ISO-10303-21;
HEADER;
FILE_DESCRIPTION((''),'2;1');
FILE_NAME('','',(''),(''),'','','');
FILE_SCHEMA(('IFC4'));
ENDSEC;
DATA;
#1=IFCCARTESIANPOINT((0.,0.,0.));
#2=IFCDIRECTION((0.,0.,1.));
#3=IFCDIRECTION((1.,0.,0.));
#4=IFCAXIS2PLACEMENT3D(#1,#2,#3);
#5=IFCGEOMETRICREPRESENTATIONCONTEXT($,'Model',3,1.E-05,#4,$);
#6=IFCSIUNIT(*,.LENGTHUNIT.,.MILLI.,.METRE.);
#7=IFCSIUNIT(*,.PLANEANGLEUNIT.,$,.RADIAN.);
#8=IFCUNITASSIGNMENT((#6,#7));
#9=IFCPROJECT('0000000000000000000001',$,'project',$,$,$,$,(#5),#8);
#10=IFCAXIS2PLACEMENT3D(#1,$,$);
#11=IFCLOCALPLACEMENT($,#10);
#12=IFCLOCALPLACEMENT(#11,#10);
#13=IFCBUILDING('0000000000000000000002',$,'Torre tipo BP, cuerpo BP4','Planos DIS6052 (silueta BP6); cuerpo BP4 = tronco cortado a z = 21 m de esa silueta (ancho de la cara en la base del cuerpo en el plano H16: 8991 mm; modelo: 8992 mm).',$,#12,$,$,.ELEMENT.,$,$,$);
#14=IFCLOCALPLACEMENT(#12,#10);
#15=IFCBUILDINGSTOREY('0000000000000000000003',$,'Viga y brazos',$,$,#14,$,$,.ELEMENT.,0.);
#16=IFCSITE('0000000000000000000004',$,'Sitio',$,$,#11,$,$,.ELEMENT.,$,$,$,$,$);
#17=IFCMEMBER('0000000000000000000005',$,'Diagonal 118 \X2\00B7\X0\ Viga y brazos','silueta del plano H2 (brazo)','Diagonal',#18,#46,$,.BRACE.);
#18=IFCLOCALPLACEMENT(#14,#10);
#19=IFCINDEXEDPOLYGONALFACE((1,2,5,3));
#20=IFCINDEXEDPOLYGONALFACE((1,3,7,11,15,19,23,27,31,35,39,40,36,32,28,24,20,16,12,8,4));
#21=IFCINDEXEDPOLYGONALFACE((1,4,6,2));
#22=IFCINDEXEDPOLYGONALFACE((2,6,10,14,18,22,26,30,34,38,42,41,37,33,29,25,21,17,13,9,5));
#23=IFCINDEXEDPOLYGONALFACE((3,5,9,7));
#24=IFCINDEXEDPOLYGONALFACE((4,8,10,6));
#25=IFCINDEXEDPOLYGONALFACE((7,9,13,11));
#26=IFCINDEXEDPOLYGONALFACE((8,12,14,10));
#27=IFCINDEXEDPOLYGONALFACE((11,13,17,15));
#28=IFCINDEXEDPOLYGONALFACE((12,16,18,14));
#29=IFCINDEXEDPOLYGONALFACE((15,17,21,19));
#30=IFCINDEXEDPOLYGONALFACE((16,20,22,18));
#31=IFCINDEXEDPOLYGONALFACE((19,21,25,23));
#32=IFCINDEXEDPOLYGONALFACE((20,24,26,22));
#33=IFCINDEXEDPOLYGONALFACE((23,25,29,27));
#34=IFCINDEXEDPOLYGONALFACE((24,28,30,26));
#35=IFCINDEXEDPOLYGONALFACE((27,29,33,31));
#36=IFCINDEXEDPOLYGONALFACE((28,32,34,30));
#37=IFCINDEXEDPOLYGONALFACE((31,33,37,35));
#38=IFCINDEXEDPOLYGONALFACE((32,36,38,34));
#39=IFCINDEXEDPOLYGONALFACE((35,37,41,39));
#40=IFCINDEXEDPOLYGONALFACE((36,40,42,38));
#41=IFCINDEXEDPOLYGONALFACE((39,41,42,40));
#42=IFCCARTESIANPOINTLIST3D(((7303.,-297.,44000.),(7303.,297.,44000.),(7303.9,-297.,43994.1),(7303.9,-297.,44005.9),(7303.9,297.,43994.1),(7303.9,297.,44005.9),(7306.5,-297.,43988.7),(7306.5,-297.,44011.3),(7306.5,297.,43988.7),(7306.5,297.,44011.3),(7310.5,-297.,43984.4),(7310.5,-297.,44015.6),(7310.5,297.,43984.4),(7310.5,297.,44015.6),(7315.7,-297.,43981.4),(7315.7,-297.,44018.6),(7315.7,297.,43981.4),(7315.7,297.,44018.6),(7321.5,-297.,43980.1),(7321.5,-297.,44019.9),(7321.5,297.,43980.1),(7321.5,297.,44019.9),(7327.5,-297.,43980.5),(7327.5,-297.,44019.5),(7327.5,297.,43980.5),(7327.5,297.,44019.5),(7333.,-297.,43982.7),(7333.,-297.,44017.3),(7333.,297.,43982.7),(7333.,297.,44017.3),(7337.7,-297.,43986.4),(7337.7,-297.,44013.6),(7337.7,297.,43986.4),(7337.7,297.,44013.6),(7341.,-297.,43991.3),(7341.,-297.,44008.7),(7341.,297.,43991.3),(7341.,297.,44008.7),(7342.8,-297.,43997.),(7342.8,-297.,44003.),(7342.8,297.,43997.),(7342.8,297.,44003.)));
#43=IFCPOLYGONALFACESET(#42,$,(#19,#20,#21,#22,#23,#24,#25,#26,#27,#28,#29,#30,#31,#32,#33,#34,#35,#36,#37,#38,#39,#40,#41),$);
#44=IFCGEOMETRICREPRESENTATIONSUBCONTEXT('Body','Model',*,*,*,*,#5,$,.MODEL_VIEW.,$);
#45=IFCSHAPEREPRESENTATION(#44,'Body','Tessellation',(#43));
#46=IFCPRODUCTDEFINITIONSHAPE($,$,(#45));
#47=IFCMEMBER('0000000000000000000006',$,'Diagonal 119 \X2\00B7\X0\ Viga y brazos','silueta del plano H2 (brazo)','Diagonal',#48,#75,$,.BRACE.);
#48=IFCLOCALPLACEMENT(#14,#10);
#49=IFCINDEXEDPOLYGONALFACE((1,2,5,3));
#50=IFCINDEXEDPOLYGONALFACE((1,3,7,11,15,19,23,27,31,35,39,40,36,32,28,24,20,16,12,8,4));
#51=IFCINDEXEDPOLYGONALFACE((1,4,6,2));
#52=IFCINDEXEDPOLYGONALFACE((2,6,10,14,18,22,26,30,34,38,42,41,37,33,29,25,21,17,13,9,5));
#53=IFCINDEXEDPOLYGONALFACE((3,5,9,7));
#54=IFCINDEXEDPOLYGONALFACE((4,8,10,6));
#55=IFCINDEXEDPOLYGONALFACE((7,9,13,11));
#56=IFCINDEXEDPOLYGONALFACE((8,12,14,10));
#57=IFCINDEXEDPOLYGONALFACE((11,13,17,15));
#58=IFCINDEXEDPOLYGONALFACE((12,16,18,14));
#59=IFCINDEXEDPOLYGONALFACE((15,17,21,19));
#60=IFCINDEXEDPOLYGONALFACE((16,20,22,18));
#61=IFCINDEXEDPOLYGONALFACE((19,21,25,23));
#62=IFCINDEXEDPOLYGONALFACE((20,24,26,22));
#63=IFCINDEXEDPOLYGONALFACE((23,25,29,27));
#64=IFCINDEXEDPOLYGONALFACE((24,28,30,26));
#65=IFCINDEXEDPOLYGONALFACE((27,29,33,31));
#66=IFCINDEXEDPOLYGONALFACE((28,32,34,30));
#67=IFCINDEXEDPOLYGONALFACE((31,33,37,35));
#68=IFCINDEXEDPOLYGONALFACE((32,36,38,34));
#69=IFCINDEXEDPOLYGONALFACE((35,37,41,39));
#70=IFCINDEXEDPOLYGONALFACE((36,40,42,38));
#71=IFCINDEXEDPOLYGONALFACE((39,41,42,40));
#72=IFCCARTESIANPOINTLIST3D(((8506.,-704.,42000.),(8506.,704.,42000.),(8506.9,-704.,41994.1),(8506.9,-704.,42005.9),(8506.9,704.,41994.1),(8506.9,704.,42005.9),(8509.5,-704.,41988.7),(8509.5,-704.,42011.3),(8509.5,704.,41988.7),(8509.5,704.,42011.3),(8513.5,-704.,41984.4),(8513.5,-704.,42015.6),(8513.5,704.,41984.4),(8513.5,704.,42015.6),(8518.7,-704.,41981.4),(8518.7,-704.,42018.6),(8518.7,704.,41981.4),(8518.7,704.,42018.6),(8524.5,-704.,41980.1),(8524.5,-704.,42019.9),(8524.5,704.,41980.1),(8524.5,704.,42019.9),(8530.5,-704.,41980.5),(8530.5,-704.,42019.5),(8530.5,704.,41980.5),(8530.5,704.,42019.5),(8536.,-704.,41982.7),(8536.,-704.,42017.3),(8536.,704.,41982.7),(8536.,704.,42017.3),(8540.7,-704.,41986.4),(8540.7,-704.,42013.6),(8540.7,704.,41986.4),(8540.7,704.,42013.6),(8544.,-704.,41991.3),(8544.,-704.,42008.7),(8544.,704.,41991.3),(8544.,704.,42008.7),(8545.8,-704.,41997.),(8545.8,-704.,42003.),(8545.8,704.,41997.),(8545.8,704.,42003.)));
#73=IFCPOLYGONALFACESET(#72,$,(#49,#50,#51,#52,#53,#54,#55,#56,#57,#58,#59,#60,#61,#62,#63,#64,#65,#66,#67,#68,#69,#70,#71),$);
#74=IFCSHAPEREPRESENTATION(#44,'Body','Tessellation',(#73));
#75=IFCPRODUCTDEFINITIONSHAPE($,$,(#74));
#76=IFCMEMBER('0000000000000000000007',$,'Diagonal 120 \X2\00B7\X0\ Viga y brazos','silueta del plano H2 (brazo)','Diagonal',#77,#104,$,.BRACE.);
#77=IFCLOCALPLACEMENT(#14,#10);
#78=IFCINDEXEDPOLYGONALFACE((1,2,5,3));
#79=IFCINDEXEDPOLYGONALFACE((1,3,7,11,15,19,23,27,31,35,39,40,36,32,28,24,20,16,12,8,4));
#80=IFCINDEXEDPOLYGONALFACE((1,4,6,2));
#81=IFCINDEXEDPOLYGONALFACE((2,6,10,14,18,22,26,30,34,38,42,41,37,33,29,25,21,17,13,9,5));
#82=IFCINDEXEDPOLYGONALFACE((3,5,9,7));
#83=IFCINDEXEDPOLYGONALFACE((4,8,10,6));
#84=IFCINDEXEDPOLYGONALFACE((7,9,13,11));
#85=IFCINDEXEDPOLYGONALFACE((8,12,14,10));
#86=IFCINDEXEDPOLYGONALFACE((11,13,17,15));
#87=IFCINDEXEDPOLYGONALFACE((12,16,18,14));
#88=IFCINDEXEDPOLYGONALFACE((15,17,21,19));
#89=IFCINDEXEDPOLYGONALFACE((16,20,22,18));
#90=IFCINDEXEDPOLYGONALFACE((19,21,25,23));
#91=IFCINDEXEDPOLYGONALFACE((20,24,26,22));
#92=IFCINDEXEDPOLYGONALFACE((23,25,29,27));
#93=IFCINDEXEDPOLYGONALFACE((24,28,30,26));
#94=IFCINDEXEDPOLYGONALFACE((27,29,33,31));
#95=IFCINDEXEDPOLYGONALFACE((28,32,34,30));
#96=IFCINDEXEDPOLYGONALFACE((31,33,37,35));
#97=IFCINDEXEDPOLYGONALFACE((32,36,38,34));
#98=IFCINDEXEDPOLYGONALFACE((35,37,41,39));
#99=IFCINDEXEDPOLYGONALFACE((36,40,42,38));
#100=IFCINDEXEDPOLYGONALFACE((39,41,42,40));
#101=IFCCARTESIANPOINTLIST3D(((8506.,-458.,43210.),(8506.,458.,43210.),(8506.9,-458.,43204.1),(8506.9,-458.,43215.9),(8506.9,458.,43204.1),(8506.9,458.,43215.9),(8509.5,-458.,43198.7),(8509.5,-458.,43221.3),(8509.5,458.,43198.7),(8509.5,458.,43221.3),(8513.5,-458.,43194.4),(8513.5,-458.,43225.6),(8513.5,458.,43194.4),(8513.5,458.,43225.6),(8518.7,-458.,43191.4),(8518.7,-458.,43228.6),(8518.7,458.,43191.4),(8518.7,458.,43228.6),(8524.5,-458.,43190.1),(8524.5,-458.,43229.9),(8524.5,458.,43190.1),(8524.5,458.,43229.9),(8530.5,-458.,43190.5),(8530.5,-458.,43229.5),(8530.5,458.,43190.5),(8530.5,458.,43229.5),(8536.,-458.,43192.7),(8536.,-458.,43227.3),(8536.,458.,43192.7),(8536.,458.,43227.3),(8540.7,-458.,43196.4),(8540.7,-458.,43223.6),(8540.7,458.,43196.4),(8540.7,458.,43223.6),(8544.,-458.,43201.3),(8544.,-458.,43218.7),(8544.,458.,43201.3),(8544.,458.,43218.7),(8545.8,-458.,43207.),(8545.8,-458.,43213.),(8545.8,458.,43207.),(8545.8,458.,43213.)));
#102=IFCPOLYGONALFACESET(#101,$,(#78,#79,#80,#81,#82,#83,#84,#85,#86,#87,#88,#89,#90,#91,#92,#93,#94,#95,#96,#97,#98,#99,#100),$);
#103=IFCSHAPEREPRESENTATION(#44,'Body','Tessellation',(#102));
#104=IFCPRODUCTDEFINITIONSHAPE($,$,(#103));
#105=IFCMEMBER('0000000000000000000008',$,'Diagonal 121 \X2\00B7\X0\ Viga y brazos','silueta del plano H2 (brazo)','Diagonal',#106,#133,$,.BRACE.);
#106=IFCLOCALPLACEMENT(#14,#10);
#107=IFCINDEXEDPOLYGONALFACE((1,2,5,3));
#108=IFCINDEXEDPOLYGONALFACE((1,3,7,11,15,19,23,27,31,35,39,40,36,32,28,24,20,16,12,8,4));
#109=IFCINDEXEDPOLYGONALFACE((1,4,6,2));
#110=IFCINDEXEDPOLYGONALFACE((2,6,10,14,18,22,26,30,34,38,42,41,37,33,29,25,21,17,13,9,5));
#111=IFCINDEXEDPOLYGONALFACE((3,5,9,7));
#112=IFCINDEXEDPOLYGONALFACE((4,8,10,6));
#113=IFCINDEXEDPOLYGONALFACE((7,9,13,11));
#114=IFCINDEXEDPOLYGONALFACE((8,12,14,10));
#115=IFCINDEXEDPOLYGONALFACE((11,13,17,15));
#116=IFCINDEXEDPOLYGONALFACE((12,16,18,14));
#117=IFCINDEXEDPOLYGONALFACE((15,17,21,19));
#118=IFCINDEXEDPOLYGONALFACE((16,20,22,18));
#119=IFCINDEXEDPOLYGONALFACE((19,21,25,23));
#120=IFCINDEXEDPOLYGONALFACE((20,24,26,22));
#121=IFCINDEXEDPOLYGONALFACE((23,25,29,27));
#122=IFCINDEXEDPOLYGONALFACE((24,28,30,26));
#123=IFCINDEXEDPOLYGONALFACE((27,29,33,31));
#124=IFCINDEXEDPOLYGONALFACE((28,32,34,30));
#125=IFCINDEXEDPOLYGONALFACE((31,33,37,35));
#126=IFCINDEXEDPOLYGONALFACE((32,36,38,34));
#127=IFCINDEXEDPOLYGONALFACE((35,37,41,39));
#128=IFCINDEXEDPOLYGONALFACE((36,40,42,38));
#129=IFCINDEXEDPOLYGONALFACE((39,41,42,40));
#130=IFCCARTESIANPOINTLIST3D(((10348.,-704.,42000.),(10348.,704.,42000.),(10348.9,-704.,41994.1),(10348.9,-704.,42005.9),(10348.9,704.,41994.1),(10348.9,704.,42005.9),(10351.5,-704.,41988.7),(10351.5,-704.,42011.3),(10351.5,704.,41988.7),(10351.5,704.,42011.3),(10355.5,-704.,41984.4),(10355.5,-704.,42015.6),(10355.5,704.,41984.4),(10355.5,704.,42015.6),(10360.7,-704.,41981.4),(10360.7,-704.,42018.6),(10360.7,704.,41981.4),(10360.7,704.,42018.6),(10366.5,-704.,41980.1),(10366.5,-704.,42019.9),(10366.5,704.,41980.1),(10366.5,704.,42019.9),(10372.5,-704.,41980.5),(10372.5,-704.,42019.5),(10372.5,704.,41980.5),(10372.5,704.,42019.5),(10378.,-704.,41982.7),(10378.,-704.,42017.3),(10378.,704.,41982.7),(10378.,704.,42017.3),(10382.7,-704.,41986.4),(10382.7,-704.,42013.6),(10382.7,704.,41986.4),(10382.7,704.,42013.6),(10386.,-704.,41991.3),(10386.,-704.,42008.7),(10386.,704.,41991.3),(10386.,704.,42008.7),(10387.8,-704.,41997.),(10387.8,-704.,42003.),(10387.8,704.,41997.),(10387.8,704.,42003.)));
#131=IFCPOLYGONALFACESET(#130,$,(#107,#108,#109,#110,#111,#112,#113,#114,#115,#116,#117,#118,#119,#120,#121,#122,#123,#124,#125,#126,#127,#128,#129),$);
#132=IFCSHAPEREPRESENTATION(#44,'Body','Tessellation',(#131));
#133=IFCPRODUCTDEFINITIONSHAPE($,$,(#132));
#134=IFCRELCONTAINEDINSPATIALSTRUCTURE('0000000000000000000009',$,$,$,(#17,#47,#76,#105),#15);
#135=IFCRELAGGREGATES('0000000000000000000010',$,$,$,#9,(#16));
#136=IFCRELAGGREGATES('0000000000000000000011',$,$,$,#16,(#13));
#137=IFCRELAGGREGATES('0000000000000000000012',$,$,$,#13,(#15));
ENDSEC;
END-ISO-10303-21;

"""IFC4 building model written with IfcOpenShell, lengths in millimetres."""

from ifc_helpers import new_model, si_unit, frame, origin, origin_with_axes, place, context, subcontext, project, spatial, circle, extrude, element, save


model = new_model("IFC4")

# Units and contexts
model_context = context("Model", 3, precision=1e-05, world=origin_with_axes())
body_context = subcontext(model_context, "Body", "Model", "MODEL_VIEW")
ifc_project = project(units=[si_unit("LENGTHUNIT", "METRE", prefix="MILLI"), si_unit("PLANEANGLEUNIT", "RADIAN")], contexts=[model_context])

# Site, building, storey
site_placement = place(None, origin())
site = spatial("IfcSite", under=ifc_project, at=site_placement, Name="Sitio", CompositionType="ELEMENT")
building_placement = place(site_placement, origin())
building = spatial("IfcBuilding", under=site, at=building_placement, Name="Torre tipo BP, cuerpo BP4", Description="Planos DIS6052 (silueta BP6); cuerpo BP4 = tronco cortado a z = 21 m de esa silueta (ancho de la cara en la base del cuerpo en el plano H16: 8991 mm; modelo: 8992 mm).", CompositionType="ELEMENT")
storey_placement = place(building_placement, origin())
storey = spatial("IfcBuildingStorey", under=building, at=storey_placement, Name="Viga y brazos", CompositionType="ELEMENT", Elevation=0.0)

# Members
member_1_placement = place(storey_placement, frame((7323.0, 297.0, 44000.0), z_axis=(0.0, -1.0, 0.0), x_axis=(-1.0, 0.0, 0.0)))
element("IfcMember", 1, at=member_1_placement, inside=storey, Name="Diagonal 118 · Viga y brazos", Description="silueta del plano H2 (brazo)", ObjectType="Diagonal", PredefinedType="BRACE", context=body_context, shape_type="SweptSolid", body=[
    extrude(circle(Radius=20.0), None, (0.0, 0.0, 1.0), 594.0),
])
member_2_placement = place(storey_placement, frame((8526.0, 704.0, 42000.0), z_axis=(0.0, -1.0, 0.0), x_axis=(-1.0, 0.0, 0.0)))
element("IfcMember", 2, at=member_2_placement, inside=storey, Name="Diagonal 119 · Viga y brazos", Description="silueta del plano H2 (brazo)", ObjectType="Diagonal", PredefinedType="BRACE", context=body_context, shape_type="SweptSolid", body=[
    extrude(circle(Radius=20.0), None, (0.0, 0.0, 1.0), 1408.0),
])
member_3_placement = place(storey_placement, frame((8526.0, 458.0, 43210.0), z_axis=(0.0, -1.0, 0.0), x_axis=(-1.0, 0.0, 0.0)))
element("IfcMember", 3, at=member_3_placement, inside=storey, Name="Diagonal 120 · Viga y brazos", Description="silueta del plano H2 (brazo)", ObjectType="Diagonal", PredefinedType="BRACE", context=body_context, shape_type="SweptSolid", body=[
    extrude(circle(Radius=20.0), None, (0.0, 0.0, 1.0), 916.0),
])
member_4_placement = place(storey_placement, frame((10368.0, 704.0, 42000.0), z_axis=(0.0, -1.0, 0.0), x_axis=(-1.0, 0.0, 0.0)))
element("IfcMember", 4, at=member_4_placement, inside=storey, Name="Diagonal 121 · Viga y brazos", Description="silueta del plano H2 (brazo)", ObjectType="Diagonal", PredefinedType="BRACE", context=body_context, shape_type="SweptSolid", body=[
    extrude(circle(Radius=20.0), None, (0.0, 0.0, 1.0), 1408.0),
])

save(model, "model.ifc")
